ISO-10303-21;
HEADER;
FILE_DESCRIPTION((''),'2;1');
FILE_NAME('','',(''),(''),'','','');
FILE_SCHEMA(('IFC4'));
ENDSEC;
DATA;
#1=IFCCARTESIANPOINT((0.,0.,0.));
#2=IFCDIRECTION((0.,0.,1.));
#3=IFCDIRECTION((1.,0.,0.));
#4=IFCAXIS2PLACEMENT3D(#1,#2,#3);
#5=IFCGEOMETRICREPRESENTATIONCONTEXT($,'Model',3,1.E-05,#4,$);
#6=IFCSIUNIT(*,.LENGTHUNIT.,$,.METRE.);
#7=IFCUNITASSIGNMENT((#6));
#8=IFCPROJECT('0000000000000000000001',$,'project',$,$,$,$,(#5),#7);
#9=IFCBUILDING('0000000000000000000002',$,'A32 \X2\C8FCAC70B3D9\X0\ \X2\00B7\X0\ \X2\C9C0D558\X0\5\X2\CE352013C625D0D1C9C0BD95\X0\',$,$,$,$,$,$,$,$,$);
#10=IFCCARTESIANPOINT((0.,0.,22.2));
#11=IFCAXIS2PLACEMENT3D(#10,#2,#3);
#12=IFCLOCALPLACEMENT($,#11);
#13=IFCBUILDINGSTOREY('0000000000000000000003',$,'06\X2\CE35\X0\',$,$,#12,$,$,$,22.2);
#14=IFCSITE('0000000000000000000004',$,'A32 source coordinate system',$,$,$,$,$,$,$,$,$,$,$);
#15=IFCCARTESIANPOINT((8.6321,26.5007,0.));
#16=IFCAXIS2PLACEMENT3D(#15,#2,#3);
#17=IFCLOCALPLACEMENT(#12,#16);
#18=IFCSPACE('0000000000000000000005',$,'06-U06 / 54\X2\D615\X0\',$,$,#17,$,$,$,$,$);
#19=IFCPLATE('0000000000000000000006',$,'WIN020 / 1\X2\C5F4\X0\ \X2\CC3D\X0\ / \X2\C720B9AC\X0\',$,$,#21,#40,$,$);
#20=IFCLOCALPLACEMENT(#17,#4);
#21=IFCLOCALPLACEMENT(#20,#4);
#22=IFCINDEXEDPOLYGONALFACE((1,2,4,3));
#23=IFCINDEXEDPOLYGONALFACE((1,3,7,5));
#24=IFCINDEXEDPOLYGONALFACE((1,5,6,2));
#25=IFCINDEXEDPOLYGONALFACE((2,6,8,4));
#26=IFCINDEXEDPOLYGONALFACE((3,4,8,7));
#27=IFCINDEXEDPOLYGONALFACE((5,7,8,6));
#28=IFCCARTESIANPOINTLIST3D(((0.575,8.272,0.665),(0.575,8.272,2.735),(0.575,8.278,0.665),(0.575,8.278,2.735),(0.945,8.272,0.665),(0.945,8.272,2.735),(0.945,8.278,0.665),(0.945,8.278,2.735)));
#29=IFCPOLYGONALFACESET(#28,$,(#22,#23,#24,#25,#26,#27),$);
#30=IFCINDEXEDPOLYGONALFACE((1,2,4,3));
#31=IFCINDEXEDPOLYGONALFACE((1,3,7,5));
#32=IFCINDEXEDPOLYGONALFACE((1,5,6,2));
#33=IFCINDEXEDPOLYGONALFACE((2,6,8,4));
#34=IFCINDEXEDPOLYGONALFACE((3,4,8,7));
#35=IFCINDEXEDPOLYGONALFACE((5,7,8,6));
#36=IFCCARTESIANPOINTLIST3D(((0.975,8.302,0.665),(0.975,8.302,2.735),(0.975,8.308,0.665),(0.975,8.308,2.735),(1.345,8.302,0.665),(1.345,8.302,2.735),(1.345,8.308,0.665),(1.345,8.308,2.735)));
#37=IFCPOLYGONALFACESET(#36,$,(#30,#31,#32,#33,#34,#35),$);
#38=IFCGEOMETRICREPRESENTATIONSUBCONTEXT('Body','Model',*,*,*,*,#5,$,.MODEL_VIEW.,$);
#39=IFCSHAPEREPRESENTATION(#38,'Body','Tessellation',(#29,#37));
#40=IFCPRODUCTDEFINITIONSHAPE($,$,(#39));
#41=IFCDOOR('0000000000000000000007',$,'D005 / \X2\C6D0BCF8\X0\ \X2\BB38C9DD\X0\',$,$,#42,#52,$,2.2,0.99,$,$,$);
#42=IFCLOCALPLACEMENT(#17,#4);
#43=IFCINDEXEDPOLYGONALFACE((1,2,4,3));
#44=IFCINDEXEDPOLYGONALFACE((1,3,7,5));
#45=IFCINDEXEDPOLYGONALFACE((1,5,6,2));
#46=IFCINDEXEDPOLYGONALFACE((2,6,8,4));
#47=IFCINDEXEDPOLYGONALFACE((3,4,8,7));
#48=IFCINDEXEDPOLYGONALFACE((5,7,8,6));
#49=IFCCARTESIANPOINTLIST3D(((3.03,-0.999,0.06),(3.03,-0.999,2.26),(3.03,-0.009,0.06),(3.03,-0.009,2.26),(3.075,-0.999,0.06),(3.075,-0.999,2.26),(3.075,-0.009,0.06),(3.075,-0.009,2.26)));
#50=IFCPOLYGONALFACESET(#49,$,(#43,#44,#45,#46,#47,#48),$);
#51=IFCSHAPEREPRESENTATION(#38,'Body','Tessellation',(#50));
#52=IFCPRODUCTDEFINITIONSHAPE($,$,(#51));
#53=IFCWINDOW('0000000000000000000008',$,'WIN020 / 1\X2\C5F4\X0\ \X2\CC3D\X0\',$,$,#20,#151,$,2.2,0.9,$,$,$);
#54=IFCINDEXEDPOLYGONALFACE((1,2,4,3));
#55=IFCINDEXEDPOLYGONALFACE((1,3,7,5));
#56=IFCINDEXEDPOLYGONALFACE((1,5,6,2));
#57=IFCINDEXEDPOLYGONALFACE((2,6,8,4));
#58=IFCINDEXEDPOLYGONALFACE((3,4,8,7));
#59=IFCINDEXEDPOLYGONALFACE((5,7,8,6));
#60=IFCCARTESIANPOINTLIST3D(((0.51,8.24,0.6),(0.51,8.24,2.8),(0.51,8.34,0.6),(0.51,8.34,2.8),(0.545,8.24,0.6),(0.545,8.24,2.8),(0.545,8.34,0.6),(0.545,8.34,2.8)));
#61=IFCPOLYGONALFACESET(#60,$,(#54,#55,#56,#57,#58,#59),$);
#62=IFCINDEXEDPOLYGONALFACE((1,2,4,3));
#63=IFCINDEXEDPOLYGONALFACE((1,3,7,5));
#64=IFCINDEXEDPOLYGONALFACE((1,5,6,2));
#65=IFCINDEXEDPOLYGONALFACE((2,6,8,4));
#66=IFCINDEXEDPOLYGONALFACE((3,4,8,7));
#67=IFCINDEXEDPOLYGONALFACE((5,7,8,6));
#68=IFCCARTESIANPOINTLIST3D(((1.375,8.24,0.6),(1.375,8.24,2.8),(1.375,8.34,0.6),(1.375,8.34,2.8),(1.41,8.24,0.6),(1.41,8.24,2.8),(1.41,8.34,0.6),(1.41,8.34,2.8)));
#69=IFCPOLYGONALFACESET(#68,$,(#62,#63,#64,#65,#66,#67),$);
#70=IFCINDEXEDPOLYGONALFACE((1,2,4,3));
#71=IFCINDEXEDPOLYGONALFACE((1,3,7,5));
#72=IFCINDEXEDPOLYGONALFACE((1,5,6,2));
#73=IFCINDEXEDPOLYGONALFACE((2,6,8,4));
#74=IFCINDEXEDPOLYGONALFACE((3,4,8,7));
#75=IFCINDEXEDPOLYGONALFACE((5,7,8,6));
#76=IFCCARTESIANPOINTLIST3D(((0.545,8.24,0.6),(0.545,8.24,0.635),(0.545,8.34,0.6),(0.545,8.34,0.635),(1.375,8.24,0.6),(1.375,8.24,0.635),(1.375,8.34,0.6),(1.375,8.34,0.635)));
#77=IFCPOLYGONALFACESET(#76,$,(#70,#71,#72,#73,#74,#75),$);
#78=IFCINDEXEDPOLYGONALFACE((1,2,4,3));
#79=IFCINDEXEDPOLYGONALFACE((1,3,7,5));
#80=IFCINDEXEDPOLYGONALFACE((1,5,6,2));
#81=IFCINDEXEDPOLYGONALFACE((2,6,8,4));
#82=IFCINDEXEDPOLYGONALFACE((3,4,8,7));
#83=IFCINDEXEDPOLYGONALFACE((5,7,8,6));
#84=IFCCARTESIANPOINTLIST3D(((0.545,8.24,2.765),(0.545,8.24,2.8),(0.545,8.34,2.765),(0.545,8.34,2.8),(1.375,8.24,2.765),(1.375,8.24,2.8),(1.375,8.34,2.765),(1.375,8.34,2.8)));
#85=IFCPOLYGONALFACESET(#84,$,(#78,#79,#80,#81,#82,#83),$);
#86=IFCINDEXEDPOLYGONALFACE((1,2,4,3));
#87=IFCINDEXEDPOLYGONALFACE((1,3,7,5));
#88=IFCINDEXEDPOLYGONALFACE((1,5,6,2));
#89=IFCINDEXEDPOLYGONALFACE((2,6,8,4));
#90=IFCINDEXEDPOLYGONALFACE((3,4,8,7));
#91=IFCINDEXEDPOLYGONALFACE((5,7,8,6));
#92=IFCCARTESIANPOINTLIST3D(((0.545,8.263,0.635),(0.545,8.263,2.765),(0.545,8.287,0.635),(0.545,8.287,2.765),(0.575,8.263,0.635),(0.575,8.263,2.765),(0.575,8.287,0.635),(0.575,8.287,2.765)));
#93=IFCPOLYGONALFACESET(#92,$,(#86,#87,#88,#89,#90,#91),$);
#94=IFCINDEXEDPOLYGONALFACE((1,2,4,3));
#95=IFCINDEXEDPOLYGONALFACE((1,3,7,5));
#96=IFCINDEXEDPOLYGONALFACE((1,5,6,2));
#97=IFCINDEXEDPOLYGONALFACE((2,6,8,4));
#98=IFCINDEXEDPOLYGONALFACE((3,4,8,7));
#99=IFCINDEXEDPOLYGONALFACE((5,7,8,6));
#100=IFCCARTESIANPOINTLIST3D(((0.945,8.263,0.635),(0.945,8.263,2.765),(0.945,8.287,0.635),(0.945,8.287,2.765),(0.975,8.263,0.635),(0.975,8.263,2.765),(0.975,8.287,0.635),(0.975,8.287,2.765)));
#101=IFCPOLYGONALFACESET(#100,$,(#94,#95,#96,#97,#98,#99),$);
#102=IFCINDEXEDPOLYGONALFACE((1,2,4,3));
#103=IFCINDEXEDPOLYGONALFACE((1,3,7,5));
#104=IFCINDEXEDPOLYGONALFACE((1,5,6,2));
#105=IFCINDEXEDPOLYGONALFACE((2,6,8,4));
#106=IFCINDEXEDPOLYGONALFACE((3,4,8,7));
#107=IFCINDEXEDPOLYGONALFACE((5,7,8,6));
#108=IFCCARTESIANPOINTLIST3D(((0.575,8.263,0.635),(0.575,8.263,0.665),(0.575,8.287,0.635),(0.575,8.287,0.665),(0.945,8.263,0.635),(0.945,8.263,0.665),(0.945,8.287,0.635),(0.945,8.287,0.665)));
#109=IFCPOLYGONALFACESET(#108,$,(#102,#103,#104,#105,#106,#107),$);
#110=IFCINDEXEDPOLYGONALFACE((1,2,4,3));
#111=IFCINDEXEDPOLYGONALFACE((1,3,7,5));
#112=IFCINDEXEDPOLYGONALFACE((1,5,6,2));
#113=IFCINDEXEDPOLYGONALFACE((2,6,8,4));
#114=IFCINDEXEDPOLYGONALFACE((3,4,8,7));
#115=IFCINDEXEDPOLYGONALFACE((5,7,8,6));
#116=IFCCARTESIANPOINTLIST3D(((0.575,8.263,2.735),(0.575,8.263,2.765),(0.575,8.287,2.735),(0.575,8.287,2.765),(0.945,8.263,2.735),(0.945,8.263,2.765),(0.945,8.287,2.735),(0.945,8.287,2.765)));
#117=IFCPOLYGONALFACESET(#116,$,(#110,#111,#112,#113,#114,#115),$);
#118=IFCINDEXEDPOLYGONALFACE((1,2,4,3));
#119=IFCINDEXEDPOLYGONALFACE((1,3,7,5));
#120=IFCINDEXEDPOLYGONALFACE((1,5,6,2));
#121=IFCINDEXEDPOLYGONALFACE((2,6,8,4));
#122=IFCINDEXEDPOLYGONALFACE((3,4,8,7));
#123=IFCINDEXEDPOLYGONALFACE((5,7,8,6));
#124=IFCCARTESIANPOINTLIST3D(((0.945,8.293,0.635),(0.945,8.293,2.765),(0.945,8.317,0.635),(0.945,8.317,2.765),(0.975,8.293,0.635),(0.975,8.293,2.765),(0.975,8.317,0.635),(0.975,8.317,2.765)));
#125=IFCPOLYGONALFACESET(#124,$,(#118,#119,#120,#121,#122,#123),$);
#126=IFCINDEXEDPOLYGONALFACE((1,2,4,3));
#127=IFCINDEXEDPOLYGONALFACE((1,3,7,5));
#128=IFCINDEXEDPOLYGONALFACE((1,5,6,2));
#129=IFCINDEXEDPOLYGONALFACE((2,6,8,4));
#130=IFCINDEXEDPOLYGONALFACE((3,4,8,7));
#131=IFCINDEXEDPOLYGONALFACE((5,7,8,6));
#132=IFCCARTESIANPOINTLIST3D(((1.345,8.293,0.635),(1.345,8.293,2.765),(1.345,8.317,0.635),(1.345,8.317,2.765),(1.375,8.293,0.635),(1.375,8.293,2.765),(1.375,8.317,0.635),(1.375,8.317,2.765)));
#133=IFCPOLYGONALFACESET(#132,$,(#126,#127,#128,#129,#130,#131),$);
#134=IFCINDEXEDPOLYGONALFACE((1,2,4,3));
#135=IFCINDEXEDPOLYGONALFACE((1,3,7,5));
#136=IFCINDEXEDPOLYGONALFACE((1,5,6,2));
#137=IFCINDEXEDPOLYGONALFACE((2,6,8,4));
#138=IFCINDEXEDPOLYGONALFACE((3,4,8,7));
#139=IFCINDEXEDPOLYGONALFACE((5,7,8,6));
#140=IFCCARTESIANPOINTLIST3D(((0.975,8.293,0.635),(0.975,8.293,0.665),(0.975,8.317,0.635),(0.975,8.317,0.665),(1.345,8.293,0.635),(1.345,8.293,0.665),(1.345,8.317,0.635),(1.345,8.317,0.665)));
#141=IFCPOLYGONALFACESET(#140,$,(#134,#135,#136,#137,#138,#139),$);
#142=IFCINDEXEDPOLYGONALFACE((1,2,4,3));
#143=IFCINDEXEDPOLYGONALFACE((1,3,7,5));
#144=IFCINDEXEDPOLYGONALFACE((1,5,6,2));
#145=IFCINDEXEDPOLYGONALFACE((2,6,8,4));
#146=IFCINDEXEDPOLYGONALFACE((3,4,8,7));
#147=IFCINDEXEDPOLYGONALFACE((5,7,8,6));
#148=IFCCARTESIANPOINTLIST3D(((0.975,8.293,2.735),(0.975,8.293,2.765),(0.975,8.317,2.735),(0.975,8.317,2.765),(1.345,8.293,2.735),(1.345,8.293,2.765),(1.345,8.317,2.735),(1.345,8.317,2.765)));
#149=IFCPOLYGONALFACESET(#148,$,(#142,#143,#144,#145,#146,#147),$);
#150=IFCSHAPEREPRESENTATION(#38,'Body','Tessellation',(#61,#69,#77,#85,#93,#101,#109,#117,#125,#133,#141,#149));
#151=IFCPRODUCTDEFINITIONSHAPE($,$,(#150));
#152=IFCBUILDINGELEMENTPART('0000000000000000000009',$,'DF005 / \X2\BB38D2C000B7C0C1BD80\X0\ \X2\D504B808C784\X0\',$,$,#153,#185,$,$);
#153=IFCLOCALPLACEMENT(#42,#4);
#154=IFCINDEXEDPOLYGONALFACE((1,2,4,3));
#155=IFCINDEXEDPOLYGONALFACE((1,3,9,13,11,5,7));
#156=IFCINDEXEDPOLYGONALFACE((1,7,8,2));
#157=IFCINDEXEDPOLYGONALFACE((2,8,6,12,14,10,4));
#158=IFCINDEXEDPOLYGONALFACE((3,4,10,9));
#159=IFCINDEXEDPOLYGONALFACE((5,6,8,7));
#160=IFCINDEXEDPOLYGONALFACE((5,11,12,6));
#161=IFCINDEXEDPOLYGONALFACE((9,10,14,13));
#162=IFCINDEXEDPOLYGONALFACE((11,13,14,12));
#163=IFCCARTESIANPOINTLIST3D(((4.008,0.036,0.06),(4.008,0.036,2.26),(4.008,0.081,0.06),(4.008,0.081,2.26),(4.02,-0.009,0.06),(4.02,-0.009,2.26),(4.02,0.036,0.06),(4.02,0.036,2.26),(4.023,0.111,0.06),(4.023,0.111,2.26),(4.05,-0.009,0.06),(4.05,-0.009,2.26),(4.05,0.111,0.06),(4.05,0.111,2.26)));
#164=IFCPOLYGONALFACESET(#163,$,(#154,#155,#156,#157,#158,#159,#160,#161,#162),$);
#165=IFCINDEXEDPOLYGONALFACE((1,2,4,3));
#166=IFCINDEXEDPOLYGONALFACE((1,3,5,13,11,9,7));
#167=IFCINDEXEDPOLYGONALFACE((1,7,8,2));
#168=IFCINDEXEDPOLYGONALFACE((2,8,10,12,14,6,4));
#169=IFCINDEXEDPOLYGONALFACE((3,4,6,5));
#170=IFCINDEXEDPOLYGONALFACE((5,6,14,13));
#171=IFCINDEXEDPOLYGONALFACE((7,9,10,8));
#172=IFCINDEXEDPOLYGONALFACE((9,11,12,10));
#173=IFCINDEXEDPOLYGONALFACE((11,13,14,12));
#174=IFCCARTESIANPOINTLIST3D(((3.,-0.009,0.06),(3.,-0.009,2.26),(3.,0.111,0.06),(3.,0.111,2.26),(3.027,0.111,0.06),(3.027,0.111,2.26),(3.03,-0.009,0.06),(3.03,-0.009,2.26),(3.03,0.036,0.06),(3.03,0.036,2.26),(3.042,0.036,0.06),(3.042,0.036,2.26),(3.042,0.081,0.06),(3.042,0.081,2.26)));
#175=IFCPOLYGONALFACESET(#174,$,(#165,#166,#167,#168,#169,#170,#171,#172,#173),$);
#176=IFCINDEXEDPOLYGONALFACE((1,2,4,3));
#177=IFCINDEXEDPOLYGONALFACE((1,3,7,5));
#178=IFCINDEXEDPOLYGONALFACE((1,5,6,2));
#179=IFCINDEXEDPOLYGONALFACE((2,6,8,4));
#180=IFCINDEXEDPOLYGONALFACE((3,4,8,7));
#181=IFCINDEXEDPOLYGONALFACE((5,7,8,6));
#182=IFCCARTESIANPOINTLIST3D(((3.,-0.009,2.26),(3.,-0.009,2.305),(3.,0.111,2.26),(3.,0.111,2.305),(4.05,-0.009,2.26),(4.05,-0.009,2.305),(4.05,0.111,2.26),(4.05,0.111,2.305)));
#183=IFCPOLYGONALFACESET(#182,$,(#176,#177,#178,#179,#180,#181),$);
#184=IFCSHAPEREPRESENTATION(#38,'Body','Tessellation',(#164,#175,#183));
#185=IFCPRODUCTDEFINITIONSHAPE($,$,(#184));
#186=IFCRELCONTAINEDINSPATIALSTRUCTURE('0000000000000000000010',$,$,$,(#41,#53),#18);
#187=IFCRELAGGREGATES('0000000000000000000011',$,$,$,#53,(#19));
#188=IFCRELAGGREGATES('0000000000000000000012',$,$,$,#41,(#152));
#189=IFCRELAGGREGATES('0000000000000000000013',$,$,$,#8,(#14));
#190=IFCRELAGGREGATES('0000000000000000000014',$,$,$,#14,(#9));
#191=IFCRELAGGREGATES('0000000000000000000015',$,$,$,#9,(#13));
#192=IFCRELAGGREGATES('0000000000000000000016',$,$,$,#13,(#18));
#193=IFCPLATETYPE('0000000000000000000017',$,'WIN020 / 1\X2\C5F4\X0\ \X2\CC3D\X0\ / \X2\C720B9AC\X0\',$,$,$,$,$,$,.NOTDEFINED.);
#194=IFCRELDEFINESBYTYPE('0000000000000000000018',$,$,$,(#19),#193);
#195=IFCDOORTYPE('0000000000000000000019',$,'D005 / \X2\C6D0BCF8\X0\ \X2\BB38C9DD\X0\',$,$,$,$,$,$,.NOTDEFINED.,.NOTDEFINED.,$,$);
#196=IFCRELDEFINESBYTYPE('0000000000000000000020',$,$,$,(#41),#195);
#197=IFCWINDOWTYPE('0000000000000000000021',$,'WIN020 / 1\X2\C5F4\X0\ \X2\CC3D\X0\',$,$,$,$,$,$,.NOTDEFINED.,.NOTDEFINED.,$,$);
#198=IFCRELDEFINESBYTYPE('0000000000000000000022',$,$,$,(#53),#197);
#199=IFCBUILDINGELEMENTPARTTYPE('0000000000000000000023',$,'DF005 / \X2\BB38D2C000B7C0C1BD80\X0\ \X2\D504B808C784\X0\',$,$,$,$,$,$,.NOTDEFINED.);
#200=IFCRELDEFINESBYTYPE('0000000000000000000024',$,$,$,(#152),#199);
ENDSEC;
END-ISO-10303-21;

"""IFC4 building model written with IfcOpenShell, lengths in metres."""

from ifc_helpers import new_model, si_unit, frame, origin, origin_with_axes, place, context, subcontext, project, spatial, polyline, outline, extrude, source, transform, mapped, type_object, type_shapes, element, aggregate, save


model = new_model("IFC4")

# Units and contexts
model_context = context("Model", 3, precision=1e-05, world=origin_with_axes())
body_context = subcontext(model_context, "Body", "Model", "MODEL_VIEW")
ifc_project = project(units=[si_unit("LENGTHUNIT", "METRE")], contexts=[model_context])

# Plate
storey_placement = place(None, frame((0.0, 0.0, 22.2), z_axis=(0.0, 0.0, 1.0), x_axis=(1.0, 0.0, 0.0)))
space_1_placement = place(storey_placement, frame((8.6321, 26.5007, 0.0), z_axis=(0.0, 0.0, 1.0), x_axis=(1.0, 0.0, 0.0)))
plate_type_1 = type_object("IfcPlateType", Name="WIN020 / 1열 창 / 유리", PredefinedType="NOTDEFINED")
shared_shape_1 = source(origin(), body_context, "Body", "SweptSolid", [
    extrude(outline(polyline([(0.575, 8.272), (0.575, 8.278), (0.945, 8.278), (0.945, 8.272), (0.575, 8.272)])), frame((0.0, 0.0, 0.665)), (0.0, 0.0, 1.0), 2.07),
    extrude(outline(polyline([(0.975, 8.302), (0.975, 8.308), (1.345, 8.308), (1.345, 8.302), (0.975, 8.302)])), frame((0.0, 0.0, 0.665)), (0.0, 0.0, 1.0), 2.07),
])
type_shapes(plate_type_1, [shared_shape_1])
window_1_placement = place(space_1_placement, origin_with_axes())
plate_1_placement = place(window_1_placement, origin_with_axes())
plate_1 = element("IfcPlate", 1, at=plate_1_placement, type_object=plate_type_1, Name="WIN020 / 1열 창 / 유리", context=body_context, shape_type="MappedRepresentation", body=[
    mapped(shared_shape_1, transform((0.0, 0.0, 0.0), scale=1.0)),
])

# Site, building, storey, space
site = spatial("IfcSite", under=ifc_project, Name="A32 source coordinate system")
building = spatial("IfcBuilding", under=site, Name="A32 주거동 · 지하5층–옥탑지붕")
storey = spatial("IfcBuildingStorey", under=building, at=storey_placement, Name="06층", Elevation=22.2)
space_1 = spatial("IfcSpace", under=storey, at=space_1_placement, Name="06-U06 / 54형")

# Door
door_type_1 = type_object("IfcDoorType", Name="D005 / 원본 문짝", OperationType="NOTDEFINED", PredefinedType="NOTDEFINED")
shared_shape_2 = source(origin(), body_context, "Body", "SweptSolid", [
    extrude(outline(polyline([(3.075, -0.999), (3.03, -0.999), (3.03, -0.009), (3.075, -0.009), (3.075, -0.999)])), frame((0.0, 0.0, 0.06)), (0.0, 0.0, 1.0), 2.2),
])
type_shapes(door_type_1, [shared_shape_2])
door_1_placement = place(space_1_placement, origin_with_axes())
door_1 = element("IfcDoor", 2, at=door_1_placement, inside=space_1, type_object=door_type_1, Name="D005 / 원본 문짝", OverallHeight=2.2, OverallWidth=0.99, context=body_context, shape_type="MappedRepresentation", body=[
    mapped(shared_shape_2, transform((0.0, 0.0, 0.0), scale=1.0)),
])

# Window
window_type_1 = type_object("IfcWindowType", Name="WIN020 / 1열 창", PartitioningType="NOTDEFINED", PredefinedType="NOTDEFINED")
shared_shape_3 = source(origin(), body_context, "Body", "SweptSolid", [
    extrude(outline(polyline([(0.51, 8.24), (0.51, 8.34), (0.545, 8.34), (0.545, 8.24), (0.51, 8.24)])), frame((0.0, 0.0, 0.6)), (0.0, 0.0, 1.0), 2.2),
    extrude(outline(polyline([(1.375, 8.24), (1.375, 8.34), (1.41, 8.34), (1.41, 8.24), (1.375, 8.24)])), frame((0.0, 0.0, 0.6)), (0.0, 0.0, 1.0), 2.2),
    extrude(outline(polyline([(0.545, 8.24), (0.545, 8.34), (1.375, 8.34), (1.375, 8.24), (0.545, 8.24)])), frame((0.0, 0.0, 0.6)), (0.0, 0.0, 1.0), 0.035),
    extrude(outline(polyline([(0.545, 8.24), (0.545, 8.34), (1.375, 8.34), (1.375, 8.24), (0.545, 8.24)])), frame((0.0, 0.0, 2.765)), (0.0, 0.0, 1.0), 0.035),
    extrude(outline(polyline([(0.545, 8.263), (0.545, 8.287), (0.575, 8.287), (0.575, 8.263), (0.545, 8.263)])), frame((0.0, 0.0, 0.635)), (0.0, 0.0, 1.0), 2.13),
    extrude(outline(polyline([(0.945, 8.263), (0.945, 8.287), (0.975, 8.287), (0.975, 8.263), (0.945, 8.263)])), frame((0.0, 0.0, 0.635)), (0.0, 0.0, 1.0), 2.13),
    extrude(outline(polyline([(0.575, 8.263), (0.575, 8.287), (0.945, 8.287), (0.945, 8.263), (0.575, 8.263)])), frame((0.0, 0.0, 0.635)), (0.0, 0.0, 1.0), 0.03),
    extrude(outline(polyline([(0.575, 8.263), (0.575, 8.287), (0.945, 8.287), (0.945, 8.263), (0.575, 8.263)])), frame((0.0, 0.0, 2.735)), (0.0, 0.0, 1.0), 0.03),
    extrude(outline(polyline([(0.945, 8.293), (0.945, 8.317), (0.975, 8.317), (0.975, 8.293), (0.945, 8.293)])), frame((0.0, 0.0, 0.635)), (0.0, 0.0, 1.0), 2.13),
    extrude(outline(polyline([(1.345, 8.293), (1.345, 8.317), (1.375, 8.317), (1.375, 8.293), (1.345, 8.293)])), frame((0.0, 0.0, 0.635)), (0.0, 0.0, 1.0), 2.13),
    extrude(outline(polyline([(0.975, 8.293), (0.975, 8.317), (1.345, 8.317), (1.345, 8.293), (0.975, 8.293)])), frame((0.0, 0.0, 0.635)), (0.0, 0.0, 1.0), 0.03),
    extrude(outline(polyline([(0.975, 8.293), (0.975, 8.317), (1.345, 8.317), (1.345, 8.293), (0.975, 8.293)])), frame((0.0, 0.0, 2.735)), (0.0, 0.0, 1.0), 0.03),
])
type_shapes(window_type_1, [shared_shape_3])
window_1 = element("IfcWindow", 3, at=window_1_placement, inside=space_1, type_object=window_type_1, Name="WIN020 / 1열 창", OverallHeight=2.2, OverallWidth=0.9, context=body_context, shape_type="MappedRepresentation", body=[
    mapped(shared_shape_3, transform((0.0, 0.0, 0.0), scale=1.0)),
])
aggregate(window_1, [plate_1])

# Building element part
building_element_part_type_1 = type_object("IfcBuildingElementPartType", Name="DF005 / 문틀·상부 프레임", PredefinedType="NOTDEFINED")
shared_shape_4 = source(origin(), body_context, "Body", "SweptSolid", [
    extrude(outline(polyline([(4.02, -0.009), (4.02, 0.036), (4.008, 0.036), (4.008, 0.081), (4.023, 0.111), (4.05, 0.111), (4.05, -0.009), (4.02, -0.009)])), frame((0.0, 0.0, 0.06)), (0.0, 0.0, 1.0), 2.2),
    extrude(outline(polyline([(3.0, 0.111), (3.027, 0.111), (3.042, 0.081), (3.042, 0.036), (3.03, 0.036), (3.03, -0.009), (3.0, -0.009), (3.0, 0.111)])), frame((0.0, 0.0, 0.06)), (0.0, 0.0, 1.0), 2.2),
    extrude(outline(polyline([(3.0, -0.009), (3.0, 0.111), (4.05, 0.111), (4.05, -0.009), (3.0, -0.009)])), frame((0.0, 0.0, 2.26)), (0.0, 0.0, 1.0), 0.045),
])
type_shapes(building_element_part_type_1, [shared_shape_4])
building_element_part_1_placement = place(door_1_placement, origin_with_axes())
building_element_part_1 = element("IfcBuildingElementPart", 4, at=building_element_part_1_placement, type_object=building_element_part_type_1, Name="DF005 / 문틀·상부 프레임", context=body_context, shape_type="MappedRepresentation", body=[
    mapped(shared_shape_4, transform((0.0, 0.0, 0.0), scale=1.0)),
])
aggregate(door_1, [building_element_part_1])

save(model, "model.ifc")
